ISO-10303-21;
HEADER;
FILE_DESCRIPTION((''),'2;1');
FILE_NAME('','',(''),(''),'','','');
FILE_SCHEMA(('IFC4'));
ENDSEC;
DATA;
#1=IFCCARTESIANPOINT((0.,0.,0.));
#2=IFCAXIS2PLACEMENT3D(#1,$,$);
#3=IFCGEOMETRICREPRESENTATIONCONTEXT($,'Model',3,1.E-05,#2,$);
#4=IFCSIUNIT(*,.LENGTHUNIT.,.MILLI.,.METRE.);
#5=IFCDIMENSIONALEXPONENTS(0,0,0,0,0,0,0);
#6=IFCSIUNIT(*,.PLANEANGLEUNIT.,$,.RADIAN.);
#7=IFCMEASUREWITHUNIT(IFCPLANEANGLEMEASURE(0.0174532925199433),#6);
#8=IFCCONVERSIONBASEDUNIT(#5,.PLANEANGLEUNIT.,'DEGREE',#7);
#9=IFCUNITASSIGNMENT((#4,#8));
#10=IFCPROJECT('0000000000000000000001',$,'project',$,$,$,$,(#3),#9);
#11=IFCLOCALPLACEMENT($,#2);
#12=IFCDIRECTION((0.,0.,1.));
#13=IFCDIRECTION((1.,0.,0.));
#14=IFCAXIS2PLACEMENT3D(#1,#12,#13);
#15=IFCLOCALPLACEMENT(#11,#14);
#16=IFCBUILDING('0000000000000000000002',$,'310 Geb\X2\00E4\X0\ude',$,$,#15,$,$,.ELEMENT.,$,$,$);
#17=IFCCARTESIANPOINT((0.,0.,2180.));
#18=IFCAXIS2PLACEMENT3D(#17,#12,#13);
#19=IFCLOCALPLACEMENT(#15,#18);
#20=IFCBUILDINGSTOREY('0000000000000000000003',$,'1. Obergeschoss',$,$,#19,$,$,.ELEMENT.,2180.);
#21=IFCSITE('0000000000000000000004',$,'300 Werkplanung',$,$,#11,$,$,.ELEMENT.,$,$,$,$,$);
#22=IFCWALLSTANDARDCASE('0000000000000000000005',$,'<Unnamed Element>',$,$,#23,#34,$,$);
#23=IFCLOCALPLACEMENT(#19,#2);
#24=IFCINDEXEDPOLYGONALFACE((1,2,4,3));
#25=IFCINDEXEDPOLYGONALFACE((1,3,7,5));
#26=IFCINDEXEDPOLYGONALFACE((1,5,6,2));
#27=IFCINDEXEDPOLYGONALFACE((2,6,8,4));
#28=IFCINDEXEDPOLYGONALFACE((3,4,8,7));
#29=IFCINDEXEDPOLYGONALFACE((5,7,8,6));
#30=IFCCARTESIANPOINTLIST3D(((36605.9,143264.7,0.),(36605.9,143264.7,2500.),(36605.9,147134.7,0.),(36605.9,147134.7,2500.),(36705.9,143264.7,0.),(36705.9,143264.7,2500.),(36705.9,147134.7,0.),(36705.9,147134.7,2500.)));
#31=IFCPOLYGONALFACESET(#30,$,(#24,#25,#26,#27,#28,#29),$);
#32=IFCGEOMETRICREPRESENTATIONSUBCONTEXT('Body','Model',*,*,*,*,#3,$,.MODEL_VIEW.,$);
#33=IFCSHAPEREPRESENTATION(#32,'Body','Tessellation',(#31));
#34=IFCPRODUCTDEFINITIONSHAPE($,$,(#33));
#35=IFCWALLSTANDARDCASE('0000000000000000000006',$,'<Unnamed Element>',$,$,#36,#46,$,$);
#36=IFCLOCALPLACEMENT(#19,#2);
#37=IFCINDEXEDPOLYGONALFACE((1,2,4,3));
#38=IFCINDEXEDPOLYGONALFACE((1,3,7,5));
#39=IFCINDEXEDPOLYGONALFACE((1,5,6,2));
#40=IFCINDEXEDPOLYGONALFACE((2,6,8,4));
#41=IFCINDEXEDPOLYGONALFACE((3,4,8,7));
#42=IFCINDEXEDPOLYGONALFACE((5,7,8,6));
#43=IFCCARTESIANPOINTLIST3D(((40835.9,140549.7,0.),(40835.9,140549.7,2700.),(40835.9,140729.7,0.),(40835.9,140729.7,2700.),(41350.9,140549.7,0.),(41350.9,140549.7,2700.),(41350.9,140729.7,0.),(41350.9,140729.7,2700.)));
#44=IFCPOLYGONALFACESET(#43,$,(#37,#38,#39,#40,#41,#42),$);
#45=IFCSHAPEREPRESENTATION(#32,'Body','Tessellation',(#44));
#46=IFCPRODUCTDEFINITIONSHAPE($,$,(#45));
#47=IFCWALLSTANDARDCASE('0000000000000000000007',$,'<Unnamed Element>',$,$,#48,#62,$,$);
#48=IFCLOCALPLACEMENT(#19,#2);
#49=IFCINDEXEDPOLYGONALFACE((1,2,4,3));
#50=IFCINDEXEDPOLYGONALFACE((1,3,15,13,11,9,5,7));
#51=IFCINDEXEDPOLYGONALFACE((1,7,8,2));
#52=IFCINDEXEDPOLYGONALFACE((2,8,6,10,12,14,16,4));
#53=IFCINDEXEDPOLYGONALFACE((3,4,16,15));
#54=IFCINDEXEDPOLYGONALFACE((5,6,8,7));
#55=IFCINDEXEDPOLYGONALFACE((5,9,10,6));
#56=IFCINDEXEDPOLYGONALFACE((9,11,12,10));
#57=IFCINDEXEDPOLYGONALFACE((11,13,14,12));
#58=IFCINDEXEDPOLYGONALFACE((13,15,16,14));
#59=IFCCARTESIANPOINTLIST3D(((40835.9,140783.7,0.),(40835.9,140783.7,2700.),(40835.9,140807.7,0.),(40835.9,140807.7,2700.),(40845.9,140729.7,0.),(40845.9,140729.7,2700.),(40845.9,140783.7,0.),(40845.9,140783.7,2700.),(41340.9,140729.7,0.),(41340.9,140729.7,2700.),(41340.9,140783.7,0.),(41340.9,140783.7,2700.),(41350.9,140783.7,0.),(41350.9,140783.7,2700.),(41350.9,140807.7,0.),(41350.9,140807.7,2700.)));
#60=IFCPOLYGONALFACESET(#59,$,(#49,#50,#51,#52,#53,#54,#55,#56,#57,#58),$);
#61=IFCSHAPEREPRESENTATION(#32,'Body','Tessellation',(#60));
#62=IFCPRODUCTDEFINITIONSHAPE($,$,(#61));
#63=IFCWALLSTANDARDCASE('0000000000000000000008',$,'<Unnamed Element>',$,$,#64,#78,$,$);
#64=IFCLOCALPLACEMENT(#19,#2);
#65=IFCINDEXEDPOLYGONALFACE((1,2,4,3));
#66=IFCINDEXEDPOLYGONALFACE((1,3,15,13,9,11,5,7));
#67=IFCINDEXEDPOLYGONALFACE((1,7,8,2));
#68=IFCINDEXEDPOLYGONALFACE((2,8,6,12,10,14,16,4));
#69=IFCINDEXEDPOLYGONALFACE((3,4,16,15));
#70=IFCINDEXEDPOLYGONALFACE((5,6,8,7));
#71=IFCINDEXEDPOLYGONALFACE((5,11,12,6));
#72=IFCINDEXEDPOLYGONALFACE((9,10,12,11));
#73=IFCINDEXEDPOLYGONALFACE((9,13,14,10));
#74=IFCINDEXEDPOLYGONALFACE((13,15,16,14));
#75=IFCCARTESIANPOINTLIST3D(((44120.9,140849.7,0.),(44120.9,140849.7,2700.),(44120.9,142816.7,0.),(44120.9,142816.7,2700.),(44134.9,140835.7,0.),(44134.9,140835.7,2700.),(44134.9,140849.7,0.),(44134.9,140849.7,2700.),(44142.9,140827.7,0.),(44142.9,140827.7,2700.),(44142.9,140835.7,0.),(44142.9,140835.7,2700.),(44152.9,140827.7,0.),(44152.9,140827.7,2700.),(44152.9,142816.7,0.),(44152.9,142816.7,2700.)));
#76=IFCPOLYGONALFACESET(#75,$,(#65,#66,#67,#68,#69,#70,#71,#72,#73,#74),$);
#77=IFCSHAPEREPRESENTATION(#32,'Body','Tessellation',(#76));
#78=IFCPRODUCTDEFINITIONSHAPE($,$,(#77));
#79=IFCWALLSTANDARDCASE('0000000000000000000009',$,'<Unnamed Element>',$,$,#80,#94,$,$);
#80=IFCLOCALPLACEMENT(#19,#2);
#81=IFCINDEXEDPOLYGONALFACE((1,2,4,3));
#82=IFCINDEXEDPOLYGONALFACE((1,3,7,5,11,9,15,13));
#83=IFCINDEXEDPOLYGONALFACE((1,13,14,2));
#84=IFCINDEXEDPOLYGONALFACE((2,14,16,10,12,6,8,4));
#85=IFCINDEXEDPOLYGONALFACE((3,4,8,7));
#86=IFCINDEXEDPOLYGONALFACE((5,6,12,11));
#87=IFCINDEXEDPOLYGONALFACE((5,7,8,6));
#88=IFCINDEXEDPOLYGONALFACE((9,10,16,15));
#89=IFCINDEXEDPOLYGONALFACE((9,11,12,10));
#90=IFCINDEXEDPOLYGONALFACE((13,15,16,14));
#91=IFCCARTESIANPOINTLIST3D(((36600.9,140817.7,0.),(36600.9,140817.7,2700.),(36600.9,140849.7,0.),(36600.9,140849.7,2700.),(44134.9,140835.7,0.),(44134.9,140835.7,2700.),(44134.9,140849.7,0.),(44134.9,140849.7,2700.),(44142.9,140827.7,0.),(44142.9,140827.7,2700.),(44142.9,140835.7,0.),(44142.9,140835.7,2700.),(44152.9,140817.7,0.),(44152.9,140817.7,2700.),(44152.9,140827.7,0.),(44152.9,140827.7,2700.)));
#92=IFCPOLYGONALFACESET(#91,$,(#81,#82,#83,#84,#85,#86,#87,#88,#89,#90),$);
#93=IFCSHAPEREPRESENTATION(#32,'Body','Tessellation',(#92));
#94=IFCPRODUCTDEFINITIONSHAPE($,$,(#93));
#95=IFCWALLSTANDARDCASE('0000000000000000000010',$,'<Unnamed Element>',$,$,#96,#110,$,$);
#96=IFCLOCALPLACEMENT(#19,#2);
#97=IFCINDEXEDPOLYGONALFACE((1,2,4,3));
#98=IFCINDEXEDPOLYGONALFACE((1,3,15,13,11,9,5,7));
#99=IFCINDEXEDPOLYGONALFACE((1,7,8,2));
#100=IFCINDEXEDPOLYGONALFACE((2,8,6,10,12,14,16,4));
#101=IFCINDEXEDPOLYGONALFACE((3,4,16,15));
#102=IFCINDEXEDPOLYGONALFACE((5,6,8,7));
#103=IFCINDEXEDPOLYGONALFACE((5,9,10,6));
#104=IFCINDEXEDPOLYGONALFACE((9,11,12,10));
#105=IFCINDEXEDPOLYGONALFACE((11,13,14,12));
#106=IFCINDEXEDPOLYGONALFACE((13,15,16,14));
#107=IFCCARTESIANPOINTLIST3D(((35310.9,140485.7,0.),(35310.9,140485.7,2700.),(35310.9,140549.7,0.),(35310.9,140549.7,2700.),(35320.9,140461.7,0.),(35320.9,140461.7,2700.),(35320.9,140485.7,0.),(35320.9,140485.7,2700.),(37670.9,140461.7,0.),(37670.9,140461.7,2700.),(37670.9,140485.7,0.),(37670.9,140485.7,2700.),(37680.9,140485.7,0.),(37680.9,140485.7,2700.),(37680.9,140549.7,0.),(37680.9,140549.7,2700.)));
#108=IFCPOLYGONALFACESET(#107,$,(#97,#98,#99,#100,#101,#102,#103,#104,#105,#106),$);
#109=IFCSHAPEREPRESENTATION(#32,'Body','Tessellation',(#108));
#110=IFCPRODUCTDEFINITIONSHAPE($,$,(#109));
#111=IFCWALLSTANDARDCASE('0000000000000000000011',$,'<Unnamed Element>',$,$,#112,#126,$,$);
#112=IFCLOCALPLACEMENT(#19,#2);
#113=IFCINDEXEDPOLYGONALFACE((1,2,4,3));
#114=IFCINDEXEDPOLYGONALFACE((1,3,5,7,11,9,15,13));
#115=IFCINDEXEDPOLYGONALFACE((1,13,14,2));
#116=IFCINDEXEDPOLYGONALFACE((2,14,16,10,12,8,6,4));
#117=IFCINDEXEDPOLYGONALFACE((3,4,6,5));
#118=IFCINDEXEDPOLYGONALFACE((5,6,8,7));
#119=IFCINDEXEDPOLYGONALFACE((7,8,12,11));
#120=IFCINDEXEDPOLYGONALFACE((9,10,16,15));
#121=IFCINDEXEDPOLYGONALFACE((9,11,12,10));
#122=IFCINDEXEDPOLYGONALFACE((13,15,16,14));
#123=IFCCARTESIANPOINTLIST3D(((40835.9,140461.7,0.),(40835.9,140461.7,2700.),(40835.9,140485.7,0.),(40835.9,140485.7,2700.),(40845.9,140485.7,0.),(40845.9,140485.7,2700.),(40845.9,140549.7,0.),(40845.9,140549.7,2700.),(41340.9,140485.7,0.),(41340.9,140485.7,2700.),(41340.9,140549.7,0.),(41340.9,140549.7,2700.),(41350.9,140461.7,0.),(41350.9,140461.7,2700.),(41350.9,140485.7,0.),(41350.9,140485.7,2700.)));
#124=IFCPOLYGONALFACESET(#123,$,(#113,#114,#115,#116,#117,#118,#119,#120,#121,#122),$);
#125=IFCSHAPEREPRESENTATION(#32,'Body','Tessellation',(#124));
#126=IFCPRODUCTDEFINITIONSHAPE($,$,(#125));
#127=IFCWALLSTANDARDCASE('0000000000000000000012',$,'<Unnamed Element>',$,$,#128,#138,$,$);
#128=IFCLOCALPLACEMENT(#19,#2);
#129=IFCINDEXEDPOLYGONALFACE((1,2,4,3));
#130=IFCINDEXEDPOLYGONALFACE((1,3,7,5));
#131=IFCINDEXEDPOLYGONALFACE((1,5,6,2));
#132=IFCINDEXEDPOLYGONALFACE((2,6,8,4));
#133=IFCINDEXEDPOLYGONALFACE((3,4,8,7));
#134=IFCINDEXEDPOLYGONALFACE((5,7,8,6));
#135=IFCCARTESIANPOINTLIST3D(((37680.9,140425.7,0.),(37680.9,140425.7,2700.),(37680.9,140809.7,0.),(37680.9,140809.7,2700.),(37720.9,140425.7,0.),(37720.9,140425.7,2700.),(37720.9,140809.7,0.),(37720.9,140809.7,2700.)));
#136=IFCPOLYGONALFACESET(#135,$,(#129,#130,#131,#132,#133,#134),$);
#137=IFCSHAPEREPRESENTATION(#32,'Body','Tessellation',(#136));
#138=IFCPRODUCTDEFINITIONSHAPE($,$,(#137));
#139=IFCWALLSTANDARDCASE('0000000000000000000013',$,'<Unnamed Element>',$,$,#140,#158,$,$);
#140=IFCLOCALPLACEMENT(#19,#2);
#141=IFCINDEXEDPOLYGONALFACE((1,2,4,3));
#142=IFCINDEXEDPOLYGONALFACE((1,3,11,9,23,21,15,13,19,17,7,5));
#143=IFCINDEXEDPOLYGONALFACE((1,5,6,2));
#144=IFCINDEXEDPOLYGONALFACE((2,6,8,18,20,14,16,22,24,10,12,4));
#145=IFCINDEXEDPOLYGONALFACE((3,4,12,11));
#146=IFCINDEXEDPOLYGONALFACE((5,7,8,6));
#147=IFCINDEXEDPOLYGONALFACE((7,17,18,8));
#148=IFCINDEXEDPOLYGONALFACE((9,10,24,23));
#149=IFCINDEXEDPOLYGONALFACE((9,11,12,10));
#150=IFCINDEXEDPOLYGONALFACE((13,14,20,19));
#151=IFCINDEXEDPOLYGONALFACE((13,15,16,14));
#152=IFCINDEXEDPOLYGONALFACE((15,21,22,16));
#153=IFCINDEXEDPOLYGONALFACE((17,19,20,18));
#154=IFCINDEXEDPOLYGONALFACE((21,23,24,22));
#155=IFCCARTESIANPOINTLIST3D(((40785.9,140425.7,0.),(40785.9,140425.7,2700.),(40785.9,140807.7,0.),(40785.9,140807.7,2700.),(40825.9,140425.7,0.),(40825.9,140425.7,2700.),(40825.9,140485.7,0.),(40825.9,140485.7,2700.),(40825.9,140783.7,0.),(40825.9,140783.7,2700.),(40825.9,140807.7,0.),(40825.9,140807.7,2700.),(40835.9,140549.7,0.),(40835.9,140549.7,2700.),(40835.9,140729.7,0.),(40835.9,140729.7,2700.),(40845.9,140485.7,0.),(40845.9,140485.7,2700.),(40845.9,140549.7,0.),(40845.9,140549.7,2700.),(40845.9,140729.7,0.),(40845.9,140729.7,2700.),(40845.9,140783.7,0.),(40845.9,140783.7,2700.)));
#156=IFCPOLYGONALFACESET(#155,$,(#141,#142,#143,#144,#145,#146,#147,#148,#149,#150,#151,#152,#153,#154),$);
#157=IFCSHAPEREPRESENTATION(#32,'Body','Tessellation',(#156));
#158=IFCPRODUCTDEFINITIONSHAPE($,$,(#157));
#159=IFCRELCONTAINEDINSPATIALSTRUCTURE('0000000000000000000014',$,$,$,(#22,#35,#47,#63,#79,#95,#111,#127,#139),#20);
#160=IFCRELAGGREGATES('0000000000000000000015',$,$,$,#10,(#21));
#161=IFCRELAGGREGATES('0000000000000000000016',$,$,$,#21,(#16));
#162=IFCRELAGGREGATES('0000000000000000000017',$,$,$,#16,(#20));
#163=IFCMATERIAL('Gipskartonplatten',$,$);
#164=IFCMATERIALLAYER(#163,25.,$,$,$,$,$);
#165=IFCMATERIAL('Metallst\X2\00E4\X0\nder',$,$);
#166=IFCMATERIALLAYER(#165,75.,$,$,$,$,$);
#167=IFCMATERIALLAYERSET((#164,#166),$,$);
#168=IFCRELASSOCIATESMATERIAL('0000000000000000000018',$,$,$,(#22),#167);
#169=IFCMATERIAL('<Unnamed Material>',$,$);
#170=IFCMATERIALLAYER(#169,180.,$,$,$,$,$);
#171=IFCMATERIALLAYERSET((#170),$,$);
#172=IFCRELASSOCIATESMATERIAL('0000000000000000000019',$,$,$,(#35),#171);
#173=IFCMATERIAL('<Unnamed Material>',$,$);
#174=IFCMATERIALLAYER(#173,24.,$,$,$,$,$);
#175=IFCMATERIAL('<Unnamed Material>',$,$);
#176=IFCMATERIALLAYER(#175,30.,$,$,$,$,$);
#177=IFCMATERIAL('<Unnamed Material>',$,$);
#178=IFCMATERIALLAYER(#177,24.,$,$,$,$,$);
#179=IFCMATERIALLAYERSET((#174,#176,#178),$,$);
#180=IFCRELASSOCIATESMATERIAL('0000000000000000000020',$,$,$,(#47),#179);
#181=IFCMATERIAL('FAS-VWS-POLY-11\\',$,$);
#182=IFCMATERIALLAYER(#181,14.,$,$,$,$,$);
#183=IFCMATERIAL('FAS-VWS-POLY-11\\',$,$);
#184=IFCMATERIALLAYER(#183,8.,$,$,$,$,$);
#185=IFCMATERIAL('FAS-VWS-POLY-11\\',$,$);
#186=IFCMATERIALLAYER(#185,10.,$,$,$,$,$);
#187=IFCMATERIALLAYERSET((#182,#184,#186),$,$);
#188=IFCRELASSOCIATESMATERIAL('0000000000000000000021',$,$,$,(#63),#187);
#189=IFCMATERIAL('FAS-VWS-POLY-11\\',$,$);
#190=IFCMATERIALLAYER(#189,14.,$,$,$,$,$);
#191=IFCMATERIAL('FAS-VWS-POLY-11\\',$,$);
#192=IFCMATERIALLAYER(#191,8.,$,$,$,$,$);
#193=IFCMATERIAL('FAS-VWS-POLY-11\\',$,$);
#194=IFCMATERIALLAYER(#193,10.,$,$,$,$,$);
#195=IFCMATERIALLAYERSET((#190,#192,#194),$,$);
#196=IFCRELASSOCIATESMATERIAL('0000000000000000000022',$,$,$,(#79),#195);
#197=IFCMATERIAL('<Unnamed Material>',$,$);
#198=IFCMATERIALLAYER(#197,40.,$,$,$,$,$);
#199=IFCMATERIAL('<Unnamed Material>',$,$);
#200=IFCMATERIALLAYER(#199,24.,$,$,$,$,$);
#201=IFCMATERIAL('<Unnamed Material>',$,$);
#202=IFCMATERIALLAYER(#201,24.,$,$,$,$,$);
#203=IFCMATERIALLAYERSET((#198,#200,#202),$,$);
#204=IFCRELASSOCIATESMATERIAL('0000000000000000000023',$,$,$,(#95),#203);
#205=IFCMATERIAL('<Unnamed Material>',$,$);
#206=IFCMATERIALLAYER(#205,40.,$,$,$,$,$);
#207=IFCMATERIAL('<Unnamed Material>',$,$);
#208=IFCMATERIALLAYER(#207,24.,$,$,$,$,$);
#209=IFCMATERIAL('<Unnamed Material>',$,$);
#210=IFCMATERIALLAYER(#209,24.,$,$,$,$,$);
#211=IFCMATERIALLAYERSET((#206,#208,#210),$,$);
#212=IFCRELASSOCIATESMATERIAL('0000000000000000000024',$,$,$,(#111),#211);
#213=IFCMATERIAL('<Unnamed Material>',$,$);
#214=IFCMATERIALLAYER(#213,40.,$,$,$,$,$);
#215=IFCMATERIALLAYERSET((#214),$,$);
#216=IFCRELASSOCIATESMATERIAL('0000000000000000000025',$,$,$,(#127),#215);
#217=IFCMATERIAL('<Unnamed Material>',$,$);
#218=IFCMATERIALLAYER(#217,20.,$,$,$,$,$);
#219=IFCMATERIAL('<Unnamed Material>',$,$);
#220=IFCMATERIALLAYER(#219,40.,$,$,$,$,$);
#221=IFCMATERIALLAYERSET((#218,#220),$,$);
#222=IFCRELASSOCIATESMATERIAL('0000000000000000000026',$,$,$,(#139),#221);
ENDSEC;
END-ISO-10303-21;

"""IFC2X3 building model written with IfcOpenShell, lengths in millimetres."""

from ifc_helpers import new_model, entity, si_unit, converted_unit, frame, frame_2d, origin, origin_with_axes, place, context, subcontext, project, spatial, polyline, rectangle, outline, extrude, material, layer, layer_set, layer_usage, element, save


model = new_model("IFC2X3")

# Units and contexts
model_context = context("Model", 3, precision=1e-05, world=origin())
body_context = subcontext(model_context, "Body", "Model", "MODEL_VIEW")
ifc_project = project(units=[si_unit("LENGTHUNIT", "METRE", prefix="MILLI"), converted_unit("PLANEANGLEUNIT", "DEGREE", entity("IfcPlaneAngleMeasure", 0.0174532925199433), si_unit("PLANEANGLEUNIT", "RADIAN"), dimensions=[0, 0, 0, 0, 0, 0, 0])], contexts=[model_context])

# Site, building, storey
site_placement = place(None, origin())
site = spatial("IfcSite", under=ifc_project, at=site_placement, Name="300 Werkplanung", CompositionType="ELEMENT")
building_placement = place(site_placement, origin_with_axes())
building = spatial("IfcBuilding", under=site, at=building_placement, Name="310 Gebäude", CompositionType="ELEMENT")
storey_placement = place(building_placement, frame((0.0, 0.0, 2180.0), z_axis=(0.0, 0.0, 1.0), x_axis=(1.0, 0.0, 0.0)))
storey = spatial("IfcBuildingStorey", under=building, at=storey_placement, Name="1. Obergeschoss", CompositionType="ELEMENT", Elevation=2180.0)

# Walls
ifc_material_1 = material(Name="Gipskartonplatten")
ifc_layer_1 = layer(ifc_material_1, 25.0)
ifc_material_2 = material(Name="Metallständer")
ifc_layer_2 = layer(ifc_material_2, 75.0)
ifc_layer_set_1 = layer_set([ifc_layer_1, ifc_layer_2])
ifc_layer_usage_1 = layer_usage(ifc_layer_set_1, "AXIS2", "POSITIVE", 0.0)
wall_1_placement = place(storey_placement, frame((36705.9, 143264.7, 0.0), z_axis=(0.0, 0.0, 1.0), x_axis=(0.0, 1.0, 0.0)))
element("IfcWallStandardCase", 1, at=wall_1_placement, inside=storey, material=ifc_layer_usage_1, Name="<Unnamed Element>", context=body_context, shape_type="SweptSolid", body=[
    extrude(rectangle(XDim=3870.0, YDim=100.0, at=frame_2d((1935.0, 50.0), x_axis=(1.0, 0.0))), origin_with_axes(), (0.0, 0.0, 1.0), 2500.0),
])
ifc_material_3 = material(Name="<Unnamed Material>")
ifc_layer_3 = layer(ifc_material_3, 180.0)
ifc_layer_set_2 = layer_set([ifc_layer_3])
ifc_layer_usage_2 = layer_usage(ifc_layer_set_2, "AXIS2", "POSITIVE", 0.0)
wall_2_placement = place(storey_placement, frame((40835.9, 140549.7, 0.0), z_axis=(0.0, 0.0, 1.0), x_axis=(1.0, 0.0, 0.0)))
element("IfcWallStandardCase", 2, at=wall_2_placement, inside=storey, material=ifc_layer_usage_2, Name="<Unnamed Element>", context=body_context, shape_type="SweptSolid", body=[
    extrude(rectangle(XDim=515.0, YDim=180.0, at=frame_2d((257.5, 90.0), x_axis=(1.0, 0.0))), origin_with_axes(), (0.0, 0.0, 1.0), 2700.0),
])
ifc_material_4 = material(Name="<Unnamed Material>")
ifc_layer_4 = layer(ifc_material_4, 24.0)
ifc_material_5 = material(Name="<Unnamed Material>")
ifc_layer_5 = layer(ifc_material_5, 30.0)
ifc_material_6 = material(Name="<Unnamed Material>")
ifc_layer_6 = layer(ifc_material_6, 24.0)
ifc_layer_set_3 = layer_set([ifc_layer_4, ifc_layer_5, ifc_layer_6])
ifc_layer_usage_3 = layer_usage(ifc_layer_set_3, "AXIS2", "POSITIVE", 0.0)
wall_3_placement = place(storey_placement, frame((40845.9, 140729.7, 0.0), z_axis=(0.0, 0.0, 1.0), x_axis=(1.0, 0.0, 0.0)))
element("IfcWallStandardCase", 3, at=wall_3_placement, inside=storey, material=ifc_layer_usage_3, Name="<Unnamed Element>", context=body_context, shape_type="SweptSolid", body=[
    extrude(outline(polyline([(0.0, 0.0), (495.0, 0.0), (495.0, 54.0), (505.0, 54.0), (505.0, 78.0), (-10.0, 78.0), (-10.0, 54.0), (0.0, 54.0), (0.0, 0.0)])), origin_with_axes(), (0.0, 0.0, 1.0), 2700.0),
])
ifc_material_7 = material(Name="FAS-VWS-POLY-11\\")
ifc_layer_7 = layer(ifc_material_7, 14.0)
ifc_material_8 = material(Name="FAS-VWS-POLY-11\\")
ifc_layer_8 = layer(ifc_material_8, 8.0)
ifc_material_9 = material(Name="FAS-VWS-POLY-11\\")
ifc_layer_9 = layer(ifc_material_9, 10.0)
ifc_layer_set_4 = layer_set([ifc_layer_7, ifc_layer_8, ifc_layer_9])
ifc_layer_usage_4 = layer_usage(ifc_layer_set_4, "AXIS2", "POSITIVE", -32.0)
wall_4_placement = place(storey_placement, frame((44120.9, 142816.7, 0.0), z_axis=(0.0, 0.0, 1.0), x_axis=(0.0, -1.0, 0.0)))
element("IfcWallStandardCase", 4, at=wall_4_placement, inside=storey, material=ifc_layer_usage_4, Name="<Unnamed Element>", context=body_context, shape_type="SweptSolid", body=[
    extrude(outline(polyline([(0.0, 0.0), (1967.0, 0.0), (1967.0, 14.0), (1981.0, 14.0), (1981.0, 22.0), (1989.0, 22.0), (1989.0, 32.0), (0.0, 32.0), (0.0, 0.0)])), origin_with_axes(), (0.0, 0.0, 1.0), 2700.0),
])
ifc_material_10 = material(Name="FAS-VWS-POLY-11\\")
ifc_layer_10 = layer(ifc_material_10, 14.0)
ifc_material_11 = material(Name="FAS-VWS-POLY-11\\")
ifc_layer_11 = layer(ifc_material_11, 8.0)
ifc_material_12 = material(Name="FAS-VWS-POLY-11\\")
ifc_layer_12 = layer(ifc_material_12, 10.0)
ifc_layer_set_5 = layer_set([ifc_layer_10, ifc_layer_11, ifc_layer_12])
ifc_layer_usage_5 = layer_usage(ifc_layer_set_5, "AXIS2", "POSITIVE", -32.0)
wall_5_placement = place(storey_placement, frame((44134.9, 140849.7, 0.0), z_axis=(0.0, 0.0, 1.0), x_axis=(-1.0, 0.0, 0.0)))
element("IfcWallStandardCase", 5, at=wall_5_placement, inside=storey, material=ifc_layer_usage_5, Name="<Unnamed Element>", context=body_context, shape_type="SweptSolid", body=[
    extrude(outline(polyline([(-18.0, 32.0), (-18.0, 22.0), (-8.0, 22.0), (-8.0, 14.0), (0.0, 14.0), (0.0, 0.0), (7534.0, 0.0), (7534.0, 32.0), (-18.0, 32.0)])), origin_with_axes(), (0.0, 0.0, 1.0), 2700.0),
])
ifc_material_13 = material(Name="<Unnamed Material>")
ifc_layer_13 = layer(ifc_material_13, 40.0)
ifc_material_14 = material(Name="<Unnamed Material>")
ifc_layer_14 = layer(ifc_material_14, 24.0)
ifc_material_15 = material(Name="<Unnamed Material>")
ifc_layer_15 = layer(ifc_material_15, 24.0)
ifc_layer_set_6 = layer_set([ifc_layer_13, ifc_layer_14, ifc_layer_15])
ifc_layer_usage_6 = layer_usage(ifc_layer_set_6, "AXIS2", "POSITIVE", 0.0)
wall_6_placement = place(storey_placement, frame((37680.9, 140549.7, 0.0), z_axis=(0.0, 0.0, 1.0), x_axis=(-1.0, 0.0, 0.0)))
element("IfcWallStandardCase", 6, at=wall_6_placement, inside=storey, material=ifc_layer_usage_6, Name="<Unnamed Element>", context=body_context, shape_type="SweptSolid", body=[
    extrude(outline(polyline([(0.0, 0.0), (2370.0, 0.0), (2370.0, 64.0), (2360.0, 64.0), (2360.0, 88.0), (10.0, 88.0), (10.0, 64.0), (0.0, 64.0), (0.0, 0.0)])), origin_with_axes(), (0.0, 0.0, 1.0), 2700.0),
])
ifc_material_16 = material(Name="<Unnamed Material>")
ifc_layer_16 = layer(ifc_material_16, 40.0)
ifc_material_17 = material(Name="<Unnamed Material>")
ifc_layer_17 = layer(ifc_material_17, 24.0)
ifc_material_18 = material(Name="<Unnamed Material>")
ifc_layer_18 = layer(ifc_material_18, 24.0)
ifc_layer_set_7 = layer_set([ifc_layer_16, ifc_layer_17, ifc_layer_18])
ifc_layer_usage_7 = layer_usage(ifc_layer_set_7, "AXIS2", "POSITIVE", 0.0)
wall_7_placement = place(storey_placement, frame((41340.9, 140549.7, 0.0), z_axis=(0.0, 0.0, 1.0), x_axis=(-1.0, 0.0, 0.0)))
element("IfcWallStandardCase", 7, at=wall_7_placement, inside=storey, material=ifc_layer_usage_7, Name="<Unnamed Element>", context=body_context, shape_type="SweptSolid", body=[
    extrude(outline(polyline([(0.0, 0.0), (495.0, 0.0), (495.0, 64.0), (505.0, 64.0), (505.0, 88.0), (-10.0, 88.0), (-10.0, 64.0), (0.0, 64.0), (0.0, 0.0)])), origin_with_axes(), (0.0, 0.0, 1.0), 2700.0),
])
ifc_material_19 = material(Name="<Unnamed Material>")
ifc_layer_19 = layer(ifc_material_19, 40.0)
ifc_layer_set_8 = layer_set([ifc_layer_19])
ifc_layer_usage_8 = layer_usage(ifc_layer_set_8, "AXIS2", "POSITIVE", -40.0)
wall_8_placement = place(storey_placement, frame((37680.9, 140809.7, 0.0), z_axis=(0.0, 0.0, 1.0), x_axis=(0.0, -1.0, 0.0)))
element("IfcWallStandardCase", 8, at=wall_8_placement, inside=storey, material=ifc_layer_usage_8, Name="<Unnamed Element>", context=body_context, shape_type="SweptSolid", body=[
    extrude(rectangle(XDim=384.0, YDim=40.0, at=frame_2d((192.0, 20.0), x_axis=(1.0, 0.0))), origin_with_axes(), (0.0, 0.0, 1.0), 2700.0),
])
ifc_material_20 = material(Name="<Unnamed Material>")
ifc_layer_20 = layer(ifc_material_20, 20.0)
ifc_material_21 = material(Name="<Unnamed Material>")
ifc_layer_21 = layer(ifc_material_21, 40.0)
ifc_layer_set_9 = layer_set([ifc_layer_20, ifc_layer_21])
ifc_layer_usage_9 = layer_usage(ifc_layer_set_9, "AXIS2", "POSITIVE", -60.0)
wall_9_placement = place(storey_placement, frame((40845.9, 140485.7, 0.0), z_axis=(0.0, 0.0, 1.0), x_axis=(0.0, 1.0, 0.0)))
element("IfcWallStandardCase", 9, at=wall_9_placement, inside=storey, material=ifc_layer_usage_9, Name="<Unnamed Element>", context=body_context, shape_type="SweptSolid", body=[
    extrude(outline(polyline([(0.0, 0.0), (64.0, 0.0), (64.0, 10.0), (244.0, 10.0), (244.0, 0.0), (298.0, 0.0), (298.0, 20.0), (322.0, 20.0), (322.0, 60.0), (-60.0, 60.0), (-60.0, 20.0), (0.0, 20.0), (0.0, 0.0)])), origin_with_axes(), (0.0, 0.0, 1.0), 2700.0),
])

save(model, "model.ifc")
